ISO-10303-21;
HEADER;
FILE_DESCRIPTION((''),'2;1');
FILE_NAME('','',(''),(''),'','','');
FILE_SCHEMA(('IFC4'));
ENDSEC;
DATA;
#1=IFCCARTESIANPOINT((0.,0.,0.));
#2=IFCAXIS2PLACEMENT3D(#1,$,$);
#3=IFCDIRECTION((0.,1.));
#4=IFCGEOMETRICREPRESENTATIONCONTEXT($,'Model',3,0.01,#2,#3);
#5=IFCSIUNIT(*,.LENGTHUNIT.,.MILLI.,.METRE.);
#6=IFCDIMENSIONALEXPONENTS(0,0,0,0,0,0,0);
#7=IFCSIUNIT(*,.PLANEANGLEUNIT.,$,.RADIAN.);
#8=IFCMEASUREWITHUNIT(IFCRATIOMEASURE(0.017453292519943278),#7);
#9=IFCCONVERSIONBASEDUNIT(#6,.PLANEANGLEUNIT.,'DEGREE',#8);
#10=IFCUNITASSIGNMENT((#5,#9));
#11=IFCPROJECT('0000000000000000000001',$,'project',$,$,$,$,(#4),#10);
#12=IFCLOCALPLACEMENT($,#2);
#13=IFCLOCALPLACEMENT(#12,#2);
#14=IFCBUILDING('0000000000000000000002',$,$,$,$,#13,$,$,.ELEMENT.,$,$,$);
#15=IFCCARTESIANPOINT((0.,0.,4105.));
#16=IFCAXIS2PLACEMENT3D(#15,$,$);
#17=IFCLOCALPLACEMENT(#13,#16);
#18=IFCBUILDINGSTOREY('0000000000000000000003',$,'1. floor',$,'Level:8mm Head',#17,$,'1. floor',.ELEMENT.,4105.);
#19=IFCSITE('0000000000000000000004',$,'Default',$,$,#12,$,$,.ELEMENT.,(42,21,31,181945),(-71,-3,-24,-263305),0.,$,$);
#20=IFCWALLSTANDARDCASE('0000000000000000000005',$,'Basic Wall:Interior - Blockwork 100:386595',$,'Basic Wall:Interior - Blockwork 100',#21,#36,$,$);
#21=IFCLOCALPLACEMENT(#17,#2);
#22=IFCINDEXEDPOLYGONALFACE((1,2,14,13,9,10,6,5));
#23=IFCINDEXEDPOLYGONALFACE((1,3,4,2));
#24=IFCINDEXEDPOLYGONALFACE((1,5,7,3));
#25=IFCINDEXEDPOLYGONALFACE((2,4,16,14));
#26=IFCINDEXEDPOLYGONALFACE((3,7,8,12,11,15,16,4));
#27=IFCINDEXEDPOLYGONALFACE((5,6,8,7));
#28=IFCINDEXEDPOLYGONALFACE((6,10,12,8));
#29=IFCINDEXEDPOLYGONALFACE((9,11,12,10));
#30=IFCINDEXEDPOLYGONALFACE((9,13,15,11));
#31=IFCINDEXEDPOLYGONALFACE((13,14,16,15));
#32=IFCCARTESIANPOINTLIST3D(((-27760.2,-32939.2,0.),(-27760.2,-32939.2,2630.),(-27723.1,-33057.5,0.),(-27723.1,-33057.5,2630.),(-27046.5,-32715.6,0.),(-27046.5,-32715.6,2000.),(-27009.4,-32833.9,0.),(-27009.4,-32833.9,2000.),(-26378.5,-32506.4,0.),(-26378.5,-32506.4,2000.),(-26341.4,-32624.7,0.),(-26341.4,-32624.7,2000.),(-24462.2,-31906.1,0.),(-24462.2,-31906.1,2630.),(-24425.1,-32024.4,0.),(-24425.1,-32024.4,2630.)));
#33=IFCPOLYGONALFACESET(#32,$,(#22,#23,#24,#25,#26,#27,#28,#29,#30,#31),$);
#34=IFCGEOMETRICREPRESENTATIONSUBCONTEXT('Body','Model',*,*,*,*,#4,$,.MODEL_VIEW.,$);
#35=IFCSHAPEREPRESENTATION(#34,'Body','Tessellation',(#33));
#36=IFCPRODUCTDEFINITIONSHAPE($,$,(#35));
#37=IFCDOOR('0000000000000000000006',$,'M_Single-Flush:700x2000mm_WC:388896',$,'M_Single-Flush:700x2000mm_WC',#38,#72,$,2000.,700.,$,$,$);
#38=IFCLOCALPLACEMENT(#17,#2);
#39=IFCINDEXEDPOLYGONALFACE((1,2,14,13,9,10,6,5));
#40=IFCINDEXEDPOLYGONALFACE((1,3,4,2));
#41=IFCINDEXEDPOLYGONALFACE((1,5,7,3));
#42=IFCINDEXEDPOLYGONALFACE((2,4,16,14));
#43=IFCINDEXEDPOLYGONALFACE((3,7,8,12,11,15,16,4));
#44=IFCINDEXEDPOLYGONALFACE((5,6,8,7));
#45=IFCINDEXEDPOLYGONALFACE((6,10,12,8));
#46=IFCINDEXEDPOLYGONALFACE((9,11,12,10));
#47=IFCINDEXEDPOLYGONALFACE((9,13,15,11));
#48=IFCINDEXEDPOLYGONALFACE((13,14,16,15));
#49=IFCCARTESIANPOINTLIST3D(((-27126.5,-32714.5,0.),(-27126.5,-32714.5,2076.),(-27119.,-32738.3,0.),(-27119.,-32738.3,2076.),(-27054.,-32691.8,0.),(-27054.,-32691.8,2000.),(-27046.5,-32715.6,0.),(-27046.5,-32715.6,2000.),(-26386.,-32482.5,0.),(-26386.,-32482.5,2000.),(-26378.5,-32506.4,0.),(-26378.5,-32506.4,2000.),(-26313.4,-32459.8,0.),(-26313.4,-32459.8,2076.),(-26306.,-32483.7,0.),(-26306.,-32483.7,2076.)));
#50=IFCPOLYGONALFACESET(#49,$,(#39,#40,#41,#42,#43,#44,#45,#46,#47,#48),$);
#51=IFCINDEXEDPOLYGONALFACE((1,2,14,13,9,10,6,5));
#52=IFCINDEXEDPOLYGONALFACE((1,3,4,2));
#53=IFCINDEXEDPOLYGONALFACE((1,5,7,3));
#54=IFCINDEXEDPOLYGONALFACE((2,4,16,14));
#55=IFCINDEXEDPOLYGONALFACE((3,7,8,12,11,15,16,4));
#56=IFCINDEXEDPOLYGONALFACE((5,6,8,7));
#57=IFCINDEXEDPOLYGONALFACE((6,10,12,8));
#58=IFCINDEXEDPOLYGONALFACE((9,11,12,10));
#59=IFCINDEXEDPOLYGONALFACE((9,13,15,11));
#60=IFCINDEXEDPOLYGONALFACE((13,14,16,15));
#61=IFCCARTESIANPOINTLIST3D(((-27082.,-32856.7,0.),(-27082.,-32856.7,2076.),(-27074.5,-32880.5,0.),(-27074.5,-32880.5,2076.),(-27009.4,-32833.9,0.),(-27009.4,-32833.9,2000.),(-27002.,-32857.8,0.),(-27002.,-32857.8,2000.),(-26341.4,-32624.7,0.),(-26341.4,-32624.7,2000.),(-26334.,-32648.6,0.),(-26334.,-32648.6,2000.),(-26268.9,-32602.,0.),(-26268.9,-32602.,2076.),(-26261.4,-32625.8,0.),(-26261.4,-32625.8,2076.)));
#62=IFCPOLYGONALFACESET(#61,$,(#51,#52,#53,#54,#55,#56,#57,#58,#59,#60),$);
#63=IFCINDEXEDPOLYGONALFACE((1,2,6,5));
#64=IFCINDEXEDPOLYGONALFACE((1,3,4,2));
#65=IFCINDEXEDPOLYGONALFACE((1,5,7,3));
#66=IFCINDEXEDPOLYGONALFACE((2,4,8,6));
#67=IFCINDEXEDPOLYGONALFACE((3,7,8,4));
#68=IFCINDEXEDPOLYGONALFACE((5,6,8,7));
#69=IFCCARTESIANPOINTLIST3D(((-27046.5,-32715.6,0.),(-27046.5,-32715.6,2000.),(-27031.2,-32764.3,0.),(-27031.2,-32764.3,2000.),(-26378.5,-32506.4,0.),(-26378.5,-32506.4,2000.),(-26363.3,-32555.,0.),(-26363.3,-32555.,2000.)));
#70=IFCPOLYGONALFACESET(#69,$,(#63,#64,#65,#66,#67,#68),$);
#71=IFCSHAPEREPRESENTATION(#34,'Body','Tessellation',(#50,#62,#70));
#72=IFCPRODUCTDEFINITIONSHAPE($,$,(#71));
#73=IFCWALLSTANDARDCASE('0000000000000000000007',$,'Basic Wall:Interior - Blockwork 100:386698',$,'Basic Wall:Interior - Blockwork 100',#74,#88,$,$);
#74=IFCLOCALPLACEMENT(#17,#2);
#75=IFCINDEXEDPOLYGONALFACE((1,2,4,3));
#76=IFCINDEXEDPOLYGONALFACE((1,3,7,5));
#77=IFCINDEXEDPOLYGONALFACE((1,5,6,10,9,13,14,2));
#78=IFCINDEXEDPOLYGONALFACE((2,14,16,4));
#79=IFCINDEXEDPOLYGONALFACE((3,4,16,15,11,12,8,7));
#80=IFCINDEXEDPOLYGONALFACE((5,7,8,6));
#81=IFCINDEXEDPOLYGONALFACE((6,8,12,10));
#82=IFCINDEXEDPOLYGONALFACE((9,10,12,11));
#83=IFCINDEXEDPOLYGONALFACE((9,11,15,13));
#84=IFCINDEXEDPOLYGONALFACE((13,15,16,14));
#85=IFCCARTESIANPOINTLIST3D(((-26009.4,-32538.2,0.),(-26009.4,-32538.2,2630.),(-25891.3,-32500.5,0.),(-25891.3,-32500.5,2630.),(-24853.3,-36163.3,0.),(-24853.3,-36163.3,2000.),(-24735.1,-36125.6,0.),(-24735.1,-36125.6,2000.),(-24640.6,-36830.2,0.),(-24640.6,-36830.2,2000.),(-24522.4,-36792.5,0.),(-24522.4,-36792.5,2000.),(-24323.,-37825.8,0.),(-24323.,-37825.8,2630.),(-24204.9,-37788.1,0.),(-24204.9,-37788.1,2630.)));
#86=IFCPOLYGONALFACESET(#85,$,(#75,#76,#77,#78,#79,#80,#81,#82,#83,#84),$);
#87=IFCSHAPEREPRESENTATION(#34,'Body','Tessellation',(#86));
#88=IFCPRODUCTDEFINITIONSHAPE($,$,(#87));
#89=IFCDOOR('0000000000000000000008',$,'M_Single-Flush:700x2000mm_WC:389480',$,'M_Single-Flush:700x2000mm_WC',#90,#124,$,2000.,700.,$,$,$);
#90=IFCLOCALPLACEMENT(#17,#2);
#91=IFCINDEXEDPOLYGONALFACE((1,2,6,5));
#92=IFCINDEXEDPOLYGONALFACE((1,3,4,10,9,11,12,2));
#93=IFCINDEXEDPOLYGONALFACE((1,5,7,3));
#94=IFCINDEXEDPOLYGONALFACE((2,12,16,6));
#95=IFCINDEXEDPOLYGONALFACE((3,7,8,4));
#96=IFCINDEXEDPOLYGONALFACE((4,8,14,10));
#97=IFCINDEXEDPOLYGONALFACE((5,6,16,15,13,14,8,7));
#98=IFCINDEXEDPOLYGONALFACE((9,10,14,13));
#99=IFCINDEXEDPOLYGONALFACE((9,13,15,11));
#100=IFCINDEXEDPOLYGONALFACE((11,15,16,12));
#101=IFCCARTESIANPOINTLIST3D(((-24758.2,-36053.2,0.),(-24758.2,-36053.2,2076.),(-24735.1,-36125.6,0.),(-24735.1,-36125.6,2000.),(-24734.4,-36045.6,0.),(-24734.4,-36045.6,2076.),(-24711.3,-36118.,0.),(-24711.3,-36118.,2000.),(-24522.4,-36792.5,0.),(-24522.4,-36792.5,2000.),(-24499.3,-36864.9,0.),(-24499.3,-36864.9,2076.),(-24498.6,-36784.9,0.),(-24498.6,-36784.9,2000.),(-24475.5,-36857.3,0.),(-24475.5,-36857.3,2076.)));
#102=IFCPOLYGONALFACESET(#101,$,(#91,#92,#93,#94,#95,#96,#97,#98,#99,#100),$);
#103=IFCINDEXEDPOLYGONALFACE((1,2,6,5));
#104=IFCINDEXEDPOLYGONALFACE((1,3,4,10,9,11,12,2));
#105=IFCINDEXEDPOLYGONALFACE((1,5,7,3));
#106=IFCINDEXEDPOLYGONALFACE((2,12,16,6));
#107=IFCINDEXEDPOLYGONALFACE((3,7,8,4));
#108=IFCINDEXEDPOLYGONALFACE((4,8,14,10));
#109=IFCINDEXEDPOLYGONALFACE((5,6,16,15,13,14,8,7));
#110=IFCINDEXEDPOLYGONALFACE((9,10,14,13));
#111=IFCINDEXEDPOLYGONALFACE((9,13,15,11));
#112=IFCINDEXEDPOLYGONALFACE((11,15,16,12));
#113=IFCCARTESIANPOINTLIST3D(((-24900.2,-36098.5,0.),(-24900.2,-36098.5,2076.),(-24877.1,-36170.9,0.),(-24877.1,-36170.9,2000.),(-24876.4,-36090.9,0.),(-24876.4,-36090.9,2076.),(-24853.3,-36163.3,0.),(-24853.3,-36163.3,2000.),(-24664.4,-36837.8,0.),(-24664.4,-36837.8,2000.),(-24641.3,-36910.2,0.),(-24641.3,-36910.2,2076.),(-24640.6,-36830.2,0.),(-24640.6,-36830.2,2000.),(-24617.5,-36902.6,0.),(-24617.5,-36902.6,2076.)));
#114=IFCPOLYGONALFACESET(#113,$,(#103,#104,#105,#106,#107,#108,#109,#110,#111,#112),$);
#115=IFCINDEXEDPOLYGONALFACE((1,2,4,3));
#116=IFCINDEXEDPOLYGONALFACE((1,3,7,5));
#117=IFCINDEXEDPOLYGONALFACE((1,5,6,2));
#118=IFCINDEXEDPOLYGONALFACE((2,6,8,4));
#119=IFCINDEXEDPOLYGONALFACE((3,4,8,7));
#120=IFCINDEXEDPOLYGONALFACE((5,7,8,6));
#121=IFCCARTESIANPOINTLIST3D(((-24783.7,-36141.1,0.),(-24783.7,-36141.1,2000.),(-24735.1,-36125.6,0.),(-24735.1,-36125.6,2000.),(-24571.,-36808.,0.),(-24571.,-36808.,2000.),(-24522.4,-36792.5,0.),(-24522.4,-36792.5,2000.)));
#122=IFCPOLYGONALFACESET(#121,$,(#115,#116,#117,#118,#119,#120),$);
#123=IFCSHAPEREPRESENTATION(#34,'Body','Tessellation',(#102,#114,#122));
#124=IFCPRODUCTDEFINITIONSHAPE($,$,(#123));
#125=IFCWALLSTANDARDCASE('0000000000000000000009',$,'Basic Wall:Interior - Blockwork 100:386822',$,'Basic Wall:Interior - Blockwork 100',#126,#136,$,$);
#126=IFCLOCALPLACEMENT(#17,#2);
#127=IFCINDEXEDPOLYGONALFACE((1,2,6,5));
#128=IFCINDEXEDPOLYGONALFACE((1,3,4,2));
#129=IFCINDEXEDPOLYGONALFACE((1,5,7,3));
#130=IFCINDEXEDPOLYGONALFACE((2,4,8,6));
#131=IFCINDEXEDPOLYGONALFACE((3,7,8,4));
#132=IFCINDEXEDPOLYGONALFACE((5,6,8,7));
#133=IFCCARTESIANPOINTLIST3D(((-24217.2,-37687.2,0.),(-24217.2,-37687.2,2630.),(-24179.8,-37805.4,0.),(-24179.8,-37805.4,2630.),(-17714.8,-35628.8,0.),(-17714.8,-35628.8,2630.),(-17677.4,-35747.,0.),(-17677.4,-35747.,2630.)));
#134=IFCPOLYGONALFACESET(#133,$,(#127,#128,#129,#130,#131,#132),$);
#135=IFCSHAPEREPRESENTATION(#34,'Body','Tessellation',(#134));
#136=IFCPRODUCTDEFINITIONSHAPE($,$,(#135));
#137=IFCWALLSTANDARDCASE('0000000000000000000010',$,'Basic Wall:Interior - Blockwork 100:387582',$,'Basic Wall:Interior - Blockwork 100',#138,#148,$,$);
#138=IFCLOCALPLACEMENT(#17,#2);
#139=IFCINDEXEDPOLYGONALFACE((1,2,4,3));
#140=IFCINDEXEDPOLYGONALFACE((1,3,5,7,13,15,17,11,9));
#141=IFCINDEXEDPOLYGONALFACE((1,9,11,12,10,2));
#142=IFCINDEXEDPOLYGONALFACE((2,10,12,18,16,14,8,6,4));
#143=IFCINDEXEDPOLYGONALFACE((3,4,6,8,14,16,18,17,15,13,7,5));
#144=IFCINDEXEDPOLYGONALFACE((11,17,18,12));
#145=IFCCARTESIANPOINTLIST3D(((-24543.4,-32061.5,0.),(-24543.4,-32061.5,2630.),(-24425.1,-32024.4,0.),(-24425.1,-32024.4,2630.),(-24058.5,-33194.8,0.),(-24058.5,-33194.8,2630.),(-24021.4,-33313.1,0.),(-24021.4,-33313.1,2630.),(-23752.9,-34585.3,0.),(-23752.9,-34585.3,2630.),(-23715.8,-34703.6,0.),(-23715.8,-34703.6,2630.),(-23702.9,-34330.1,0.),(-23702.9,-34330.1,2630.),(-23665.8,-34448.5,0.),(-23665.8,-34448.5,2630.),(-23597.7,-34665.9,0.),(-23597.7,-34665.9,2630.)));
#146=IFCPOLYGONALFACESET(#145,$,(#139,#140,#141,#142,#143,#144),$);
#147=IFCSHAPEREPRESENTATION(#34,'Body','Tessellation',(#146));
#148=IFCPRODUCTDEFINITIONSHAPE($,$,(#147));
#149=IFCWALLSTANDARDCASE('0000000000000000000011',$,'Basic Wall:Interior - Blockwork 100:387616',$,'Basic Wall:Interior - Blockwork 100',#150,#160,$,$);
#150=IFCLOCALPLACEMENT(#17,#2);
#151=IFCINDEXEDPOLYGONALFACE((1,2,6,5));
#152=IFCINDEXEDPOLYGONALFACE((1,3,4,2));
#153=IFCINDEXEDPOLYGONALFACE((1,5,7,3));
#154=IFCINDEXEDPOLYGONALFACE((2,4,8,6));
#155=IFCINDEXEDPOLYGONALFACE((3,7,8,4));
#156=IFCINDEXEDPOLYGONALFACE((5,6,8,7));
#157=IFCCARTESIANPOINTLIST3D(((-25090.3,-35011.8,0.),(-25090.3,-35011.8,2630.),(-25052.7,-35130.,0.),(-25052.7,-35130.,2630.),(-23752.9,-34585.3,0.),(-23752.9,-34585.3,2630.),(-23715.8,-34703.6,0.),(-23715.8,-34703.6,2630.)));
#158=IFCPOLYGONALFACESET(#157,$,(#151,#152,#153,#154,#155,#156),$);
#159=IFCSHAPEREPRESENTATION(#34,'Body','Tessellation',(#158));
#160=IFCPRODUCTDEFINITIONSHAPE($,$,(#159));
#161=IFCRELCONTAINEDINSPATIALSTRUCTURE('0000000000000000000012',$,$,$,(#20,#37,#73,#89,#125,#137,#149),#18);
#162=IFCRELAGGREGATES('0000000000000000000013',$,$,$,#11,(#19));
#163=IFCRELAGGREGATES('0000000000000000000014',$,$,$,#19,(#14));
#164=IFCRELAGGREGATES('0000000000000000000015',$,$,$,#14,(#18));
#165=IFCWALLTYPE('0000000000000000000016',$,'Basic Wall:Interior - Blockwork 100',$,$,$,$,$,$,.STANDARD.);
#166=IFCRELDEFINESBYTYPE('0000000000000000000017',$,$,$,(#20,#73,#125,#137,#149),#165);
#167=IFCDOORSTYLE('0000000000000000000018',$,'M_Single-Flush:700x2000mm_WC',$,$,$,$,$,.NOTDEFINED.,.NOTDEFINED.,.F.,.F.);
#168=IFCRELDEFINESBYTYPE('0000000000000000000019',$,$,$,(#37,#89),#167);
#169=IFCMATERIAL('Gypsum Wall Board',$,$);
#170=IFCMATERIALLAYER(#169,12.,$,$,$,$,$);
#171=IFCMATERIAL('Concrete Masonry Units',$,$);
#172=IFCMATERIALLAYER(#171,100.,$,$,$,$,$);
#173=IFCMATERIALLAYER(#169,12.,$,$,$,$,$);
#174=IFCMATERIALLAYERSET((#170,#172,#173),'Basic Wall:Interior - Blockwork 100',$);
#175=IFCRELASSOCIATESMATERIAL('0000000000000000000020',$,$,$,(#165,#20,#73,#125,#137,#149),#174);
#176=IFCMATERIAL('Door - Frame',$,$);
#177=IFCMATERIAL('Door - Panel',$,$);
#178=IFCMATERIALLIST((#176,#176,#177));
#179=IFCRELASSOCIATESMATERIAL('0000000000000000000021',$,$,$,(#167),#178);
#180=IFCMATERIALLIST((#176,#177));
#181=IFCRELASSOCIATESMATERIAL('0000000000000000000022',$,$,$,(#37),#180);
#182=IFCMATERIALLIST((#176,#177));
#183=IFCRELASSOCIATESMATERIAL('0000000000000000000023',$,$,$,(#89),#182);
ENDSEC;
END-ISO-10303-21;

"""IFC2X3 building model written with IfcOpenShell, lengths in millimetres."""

from ifc_helpers import new_model, entity, si_unit, converted_unit, direction, frame, frame_2d, origin, origin_2d_with_axis, place, context, subcontext, project, spatial, polyline, rectangle, outline, extrude, source, transform, mapped, material, material_list, layer, layer_set, layer_usage, type_object, type_shapes, element, fill, save


model = new_model("IFC2X3")

# Units and contexts
model_context = context("Model", 3, precision=0.01, world=origin(), true_north=direction((0.0, 1.0)))
body_context = subcontext(model_context, "Body", "Model", "MODEL_VIEW")
ifc_project = project(units=[si_unit("LENGTHUNIT", "METRE", prefix="MILLI"), converted_unit("PLANEANGLEUNIT", "DEGREE", entity("IfcRatioMeasure", 0.017453292519943278), si_unit("PLANEANGLEUNIT", "RADIAN"), dimensions=[0, 0, 0, 0, 0, 0, 0])], contexts=[model_context])

# Site, building, storey
site_placement = place(None, origin())
site = spatial("IfcSite", under=ifc_project, at=site_placement, Name="Default", CompositionType="ELEMENT", RefLatitude=(42, 21, 31, 181945), RefLongitude=(-71, -3, -24, -263305), RefElevation=0.0)
building_placement = place(site_placement, origin())
building = spatial("IfcBuilding", under=site, at=building_placement, CompositionType="ELEMENT")
storey_placement = place(building_placement, frame((0.0, 0.0, 4105.0)))
storey = spatial("IfcBuildingStorey", under=building, at=storey_placement, Name="1. floor", ObjectType="Level:8mm Head", LongName="1. floor", CompositionType="ELEMENT", Elevation=4105.0)

# Walls, openings, doors
ifc_material_1 = material(Name="Gypsum Wall Board")
ifc_layer_1 = layer(ifc_material_1, 12.0)
ifc_material_2 = material(Name="Concrete Masonry Units")
ifc_layer_2 = layer(ifc_material_2, 100.0)
ifc_layer_3 = layer(ifc_material_1, 12.0)
ifc_layer_set = layer_set([ifc_layer_1, ifc_layer_2, ifc_layer_3], Name="Basic Wall:Interior - Blockwork 100")
ifc_layer_usage_1 = layer_usage(ifc_layer_set, "AXIS2", "NEGATIVE", 62.0)
wall_type = type_object("IfcWallType", Name="Basic Wall:Interior - Blockwork 100", PredefinedType="STANDARD", material=ifc_layer_set)
wall_1_placement = place(storey_placement, frame((-27741.6, -32998.3, 0.0), z_axis=(0.0, 0.0, 1.0), x_axis=(0.954277, 0.298924, 0.0)))
wall_1 = element("IfcWallStandardCase", 1, at=wall_1_placement, inside=storey, type_object=wall_type, material=ifc_layer_usage_1, Name="Basic Wall:Interior - Blockwork 100:386595", ObjectType="Basic Wall:Interior - Blockwork 100", context=body_context, shape_type="SweptSolid", body=[
    extrude(rectangle(XDim=3456.0, YDim=124.0, at=frame_2d((1728.0, 0.0), x_axis=(-1.0, 0.0))), origin(), (0.0, 0.0, 1.0), 2630.0),
])
opening_1_placement = place(wall_1_placement, frame((747.9, -62.0, 0.0)))
opening_1 = element("IfcOpeningElement", 2, at=opening_1_placement, cuts=wall_1, ObjectType="Opening", context=body_context, shape_type="SweptSolid", body=[
    extrude(rectangle(XDim=700.0, YDim=2000.0, at=frame_2d((1000.0, 350.0), x_axis=(0.0, 1.0))), frame((0.0, 0.0, 0.0), z_axis=(0.0, 1.0, 0.0), x_axis=(0.0, 0.0, 1.0)), (0.0, 0.0, 1.0), 124.0),
])
ifc_material_3 = material(Name="Door - Frame")
ifc_material_4 = material(Name="Door - Panel")
ifc_material_list_1 = material_list([ifc_material_3, ifc_material_4])
ifc_material_list_2 = material_list([ifc_material_3, ifc_material_3, ifc_material_4])
door_style_1 = type_object("IfcDoorStyle", Name="M_Single-Flush:700x2000mm_WC", ConstructionType="NOTDEFINED", OperationType="NOTDEFINED", ParameterTakesPrecedence=False, Sizeable=False, material=ifc_material_list_2)
shared_shape_1 = source(origin(), body_context, "Body", "SweptSolid", [
    extrude(outline(polyline([(-426.0, -1057.0), (426.0, -1057.0), (426.0, 1019.0), (350.0, 1019.0), (350.0, -981.0), (-350.0, -981.0), (-350.0, 1019.0), (-426.0, 1019.0), (-426.0, -1057.0)])), frame((350.0, 124.0, 1019.0), z_axis=(0.0, 1.0, 0.0), x_axis=(1.0, 0.0, 0.0)), (0.0, 0.0, 1.0), 25.0),
    extrude(outline(polyline([(-1057.0, -426.0), (1019.0, -426.0), (1019.0, -350.0), (-981.0, -350.0), (-981.0, 350.0), (1019.0, 350.0), (1019.0, 426.0), (-1057.0, 426.0), (-1057.0, -426.0)])), frame((350.0, -25.0, 1019.0), z_axis=(0.0, 1.0, 0.0), x_axis=(0.0, 0.0, -1.0)), (0.0, 0.0, 1.0), 25.0),
    extrude(rectangle(XDim=51.0, YDim=700.0, at=origin_2d_with_axis()), frame((350.0, 98.5, 0.0), z_axis=(0.0, 0.0, 1.0), x_axis=(0.0, 1.0, 0.0)), (0.0, 0.0, 1.0), 2000.0),
])
type_shapes(door_style_1, [shared_shape_1])
door_1_placement = place(opening_1_placement, origin())
door_1 = element("IfcDoor", 3, at=door_1_placement, inside=storey, type_object=door_style_1, material=ifc_material_list_1, Name="M_Single-Flush:700x2000mm_WC:388896", ObjectType="M_Single-Flush:700x2000mm_WC", OverallHeight=2000.0, OverallWidth=700.0, context=body_context, shape_type="MappedRepresentation", body=[
    mapped(shared_shape_1, transform((0.0, 0.0, 0.0), scale=1.0)),
])
fill(opening_1, door_1)
ifc_layer_usage_2 = layer_usage(ifc_layer_set, "AXIS2", "NEGATIVE", 62.0)
wall_2_placement = place(storey_placement, frame((-25950.4, -32519.3, 0.0), z_axis=(0.0, 0.0, 1.0), x_axis=(0.303856, -0.952718, 0.0)))
wall_2 = element("IfcWallStandardCase", 4, at=wall_2_placement, inside=storey, type_object=wall_type, material=ifc_layer_usage_2, Name="Basic Wall:Interior - Blockwork 100:386698", ObjectType="Basic Wall:Interior - Blockwork 100", context=body_context, shape_type="SweptSolid", body=[
    extrude(rectangle(XDim=5550.1, YDim=124.0, at=frame_2d((2775.0, 0.0), x_axis=(-1.0, 0.0))), origin(), (0.0, 0.0, 1.0), 2630.0),
])
opening_2_placement = place(wall_2_placement, frame((3805.0, -62.0, 0.0)))
opening_2 = element("IfcOpeningElement", 5, at=opening_2_placement, cuts=wall_2, ObjectType="Opening", context=body_context, shape_type="SweptSolid", body=[
    extrude(rectangle(XDim=700.0, YDim=2000.0, at=frame_2d((1000.0, 350.0), x_axis=(0.0, 1.0))), frame((0.0, 0.0, 0.0), z_axis=(0.0, 1.0, 0.0), x_axis=(0.0, 0.0, 1.0)), (0.0, 0.0, 1.0), 124.0),
])
ifc_material_list_3 = material_list([ifc_material_3, ifc_material_4])
door_2_placement = place(opening_2_placement, origin())
door_2 = element("IfcDoor", 6, at=door_2_placement, inside=storey, type_object=door_style_1, material=ifc_material_list_3, Name="M_Single-Flush:700x2000mm_WC:389480", ObjectType="M_Single-Flush:700x2000mm_WC", OverallHeight=2000.0, OverallWidth=700.0, context=body_context, shape_type="MappedRepresentation", body=[
    mapped(shared_shape_1, transform((0.0, 0.0, 0.0), scale=1.0)),
])
fill(opening_2, door_2)

# Walls
ifc_layer_usage_3 = layer_usage(ifc_layer_set, "AXIS2", "NEGATIVE", 62.0)
wall_3_placement = place(storey_placement, frame((-24198.5, -37746.3, 0.0), z_axis=(0.0, 0.0, 1.0), x_axis=(0.953372, 0.301797, 0.0)))
element("IfcWallStandardCase", 7, at=wall_3_placement, inside=storey, type_object=wall_type, material=ifc_layer_usage_3, Name="Basic Wall:Interior - Blockwork 100:386822", ObjectType="Basic Wall:Interior - Blockwork 100", context=body_context, shape_type="SweptSolid", body=[
    extrude(rectangle(XDim=6820.4, YDim=124.0, at=frame_2d((3410.2, 0.0), x_axis=(-1.0, 0.0))), origin(), (0.0, 0.0, 1.0), 2630.0),
])
ifc_layer_usage_4 = layer_usage(ifc_layer_set, "AXIS2", "NEGATIVE", 62.0)
wall_4_placement = place(storey_placement, frame((-24484.3, -32043.0, 0.0), z_axis=(0.0, 0.0, 1.0), x_axis=(0.298924, -0.954277, 0.0)))
element("IfcWallStandardCase", 8, at=wall_4_placement, inside=storey, type_object=wall_type, material=ifc_layer_usage_4, Name="Basic Wall:Interior - Blockwork 100:387582", ObjectType="Basic Wall:Interior - Blockwork 100", context=body_context, shape_type="SweptSolid", body=[
    extrude(outline(polyline([(2768.7, -62.0), (2768.1, 62.0), (2540.2, 62.0), (2416.2, 62.0), (1350.4, 62.0), (1226.4, 62.0), (0.0, 62.0), (0.0, -62.0), (2644.7, -62.0), (2768.7, -62.0)])), origin(), (0.0, 0.0, 1.0), 2630.0),
])
ifc_layer_usage_5 = layer_usage(ifc_layer_set, "AXIS2", "NEGATIVE", 62.0)
wall_5_placement = place(storey_placement, frame((-23734.0, -34644.3, 0.0), z_axis=(0.0, 0.0, 1.0), x_axis=(-0.952718, -0.303856, 0.0)))
element("IfcWallStandardCase", 9, at=wall_5_placement, inside=storey, type_object=wall_type, material=ifc_layer_usage_5, Name="Basic Wall:Interior - Blockwork 100:387616", ObjectType="Basic Wall:Interior - Blockwork 100", context=body_context, shape_type="SweptSolid", body=[
    extrude(outline(polyline([(1403.9, -62.0), (1403.9, 62.0), (0.6, 62.0), (0.0, -62.0), (1403.9, -62.0)])), origin(), (0.0, 0.0, 1.0), 2630.0),
])

save(model, "model.ifc")
